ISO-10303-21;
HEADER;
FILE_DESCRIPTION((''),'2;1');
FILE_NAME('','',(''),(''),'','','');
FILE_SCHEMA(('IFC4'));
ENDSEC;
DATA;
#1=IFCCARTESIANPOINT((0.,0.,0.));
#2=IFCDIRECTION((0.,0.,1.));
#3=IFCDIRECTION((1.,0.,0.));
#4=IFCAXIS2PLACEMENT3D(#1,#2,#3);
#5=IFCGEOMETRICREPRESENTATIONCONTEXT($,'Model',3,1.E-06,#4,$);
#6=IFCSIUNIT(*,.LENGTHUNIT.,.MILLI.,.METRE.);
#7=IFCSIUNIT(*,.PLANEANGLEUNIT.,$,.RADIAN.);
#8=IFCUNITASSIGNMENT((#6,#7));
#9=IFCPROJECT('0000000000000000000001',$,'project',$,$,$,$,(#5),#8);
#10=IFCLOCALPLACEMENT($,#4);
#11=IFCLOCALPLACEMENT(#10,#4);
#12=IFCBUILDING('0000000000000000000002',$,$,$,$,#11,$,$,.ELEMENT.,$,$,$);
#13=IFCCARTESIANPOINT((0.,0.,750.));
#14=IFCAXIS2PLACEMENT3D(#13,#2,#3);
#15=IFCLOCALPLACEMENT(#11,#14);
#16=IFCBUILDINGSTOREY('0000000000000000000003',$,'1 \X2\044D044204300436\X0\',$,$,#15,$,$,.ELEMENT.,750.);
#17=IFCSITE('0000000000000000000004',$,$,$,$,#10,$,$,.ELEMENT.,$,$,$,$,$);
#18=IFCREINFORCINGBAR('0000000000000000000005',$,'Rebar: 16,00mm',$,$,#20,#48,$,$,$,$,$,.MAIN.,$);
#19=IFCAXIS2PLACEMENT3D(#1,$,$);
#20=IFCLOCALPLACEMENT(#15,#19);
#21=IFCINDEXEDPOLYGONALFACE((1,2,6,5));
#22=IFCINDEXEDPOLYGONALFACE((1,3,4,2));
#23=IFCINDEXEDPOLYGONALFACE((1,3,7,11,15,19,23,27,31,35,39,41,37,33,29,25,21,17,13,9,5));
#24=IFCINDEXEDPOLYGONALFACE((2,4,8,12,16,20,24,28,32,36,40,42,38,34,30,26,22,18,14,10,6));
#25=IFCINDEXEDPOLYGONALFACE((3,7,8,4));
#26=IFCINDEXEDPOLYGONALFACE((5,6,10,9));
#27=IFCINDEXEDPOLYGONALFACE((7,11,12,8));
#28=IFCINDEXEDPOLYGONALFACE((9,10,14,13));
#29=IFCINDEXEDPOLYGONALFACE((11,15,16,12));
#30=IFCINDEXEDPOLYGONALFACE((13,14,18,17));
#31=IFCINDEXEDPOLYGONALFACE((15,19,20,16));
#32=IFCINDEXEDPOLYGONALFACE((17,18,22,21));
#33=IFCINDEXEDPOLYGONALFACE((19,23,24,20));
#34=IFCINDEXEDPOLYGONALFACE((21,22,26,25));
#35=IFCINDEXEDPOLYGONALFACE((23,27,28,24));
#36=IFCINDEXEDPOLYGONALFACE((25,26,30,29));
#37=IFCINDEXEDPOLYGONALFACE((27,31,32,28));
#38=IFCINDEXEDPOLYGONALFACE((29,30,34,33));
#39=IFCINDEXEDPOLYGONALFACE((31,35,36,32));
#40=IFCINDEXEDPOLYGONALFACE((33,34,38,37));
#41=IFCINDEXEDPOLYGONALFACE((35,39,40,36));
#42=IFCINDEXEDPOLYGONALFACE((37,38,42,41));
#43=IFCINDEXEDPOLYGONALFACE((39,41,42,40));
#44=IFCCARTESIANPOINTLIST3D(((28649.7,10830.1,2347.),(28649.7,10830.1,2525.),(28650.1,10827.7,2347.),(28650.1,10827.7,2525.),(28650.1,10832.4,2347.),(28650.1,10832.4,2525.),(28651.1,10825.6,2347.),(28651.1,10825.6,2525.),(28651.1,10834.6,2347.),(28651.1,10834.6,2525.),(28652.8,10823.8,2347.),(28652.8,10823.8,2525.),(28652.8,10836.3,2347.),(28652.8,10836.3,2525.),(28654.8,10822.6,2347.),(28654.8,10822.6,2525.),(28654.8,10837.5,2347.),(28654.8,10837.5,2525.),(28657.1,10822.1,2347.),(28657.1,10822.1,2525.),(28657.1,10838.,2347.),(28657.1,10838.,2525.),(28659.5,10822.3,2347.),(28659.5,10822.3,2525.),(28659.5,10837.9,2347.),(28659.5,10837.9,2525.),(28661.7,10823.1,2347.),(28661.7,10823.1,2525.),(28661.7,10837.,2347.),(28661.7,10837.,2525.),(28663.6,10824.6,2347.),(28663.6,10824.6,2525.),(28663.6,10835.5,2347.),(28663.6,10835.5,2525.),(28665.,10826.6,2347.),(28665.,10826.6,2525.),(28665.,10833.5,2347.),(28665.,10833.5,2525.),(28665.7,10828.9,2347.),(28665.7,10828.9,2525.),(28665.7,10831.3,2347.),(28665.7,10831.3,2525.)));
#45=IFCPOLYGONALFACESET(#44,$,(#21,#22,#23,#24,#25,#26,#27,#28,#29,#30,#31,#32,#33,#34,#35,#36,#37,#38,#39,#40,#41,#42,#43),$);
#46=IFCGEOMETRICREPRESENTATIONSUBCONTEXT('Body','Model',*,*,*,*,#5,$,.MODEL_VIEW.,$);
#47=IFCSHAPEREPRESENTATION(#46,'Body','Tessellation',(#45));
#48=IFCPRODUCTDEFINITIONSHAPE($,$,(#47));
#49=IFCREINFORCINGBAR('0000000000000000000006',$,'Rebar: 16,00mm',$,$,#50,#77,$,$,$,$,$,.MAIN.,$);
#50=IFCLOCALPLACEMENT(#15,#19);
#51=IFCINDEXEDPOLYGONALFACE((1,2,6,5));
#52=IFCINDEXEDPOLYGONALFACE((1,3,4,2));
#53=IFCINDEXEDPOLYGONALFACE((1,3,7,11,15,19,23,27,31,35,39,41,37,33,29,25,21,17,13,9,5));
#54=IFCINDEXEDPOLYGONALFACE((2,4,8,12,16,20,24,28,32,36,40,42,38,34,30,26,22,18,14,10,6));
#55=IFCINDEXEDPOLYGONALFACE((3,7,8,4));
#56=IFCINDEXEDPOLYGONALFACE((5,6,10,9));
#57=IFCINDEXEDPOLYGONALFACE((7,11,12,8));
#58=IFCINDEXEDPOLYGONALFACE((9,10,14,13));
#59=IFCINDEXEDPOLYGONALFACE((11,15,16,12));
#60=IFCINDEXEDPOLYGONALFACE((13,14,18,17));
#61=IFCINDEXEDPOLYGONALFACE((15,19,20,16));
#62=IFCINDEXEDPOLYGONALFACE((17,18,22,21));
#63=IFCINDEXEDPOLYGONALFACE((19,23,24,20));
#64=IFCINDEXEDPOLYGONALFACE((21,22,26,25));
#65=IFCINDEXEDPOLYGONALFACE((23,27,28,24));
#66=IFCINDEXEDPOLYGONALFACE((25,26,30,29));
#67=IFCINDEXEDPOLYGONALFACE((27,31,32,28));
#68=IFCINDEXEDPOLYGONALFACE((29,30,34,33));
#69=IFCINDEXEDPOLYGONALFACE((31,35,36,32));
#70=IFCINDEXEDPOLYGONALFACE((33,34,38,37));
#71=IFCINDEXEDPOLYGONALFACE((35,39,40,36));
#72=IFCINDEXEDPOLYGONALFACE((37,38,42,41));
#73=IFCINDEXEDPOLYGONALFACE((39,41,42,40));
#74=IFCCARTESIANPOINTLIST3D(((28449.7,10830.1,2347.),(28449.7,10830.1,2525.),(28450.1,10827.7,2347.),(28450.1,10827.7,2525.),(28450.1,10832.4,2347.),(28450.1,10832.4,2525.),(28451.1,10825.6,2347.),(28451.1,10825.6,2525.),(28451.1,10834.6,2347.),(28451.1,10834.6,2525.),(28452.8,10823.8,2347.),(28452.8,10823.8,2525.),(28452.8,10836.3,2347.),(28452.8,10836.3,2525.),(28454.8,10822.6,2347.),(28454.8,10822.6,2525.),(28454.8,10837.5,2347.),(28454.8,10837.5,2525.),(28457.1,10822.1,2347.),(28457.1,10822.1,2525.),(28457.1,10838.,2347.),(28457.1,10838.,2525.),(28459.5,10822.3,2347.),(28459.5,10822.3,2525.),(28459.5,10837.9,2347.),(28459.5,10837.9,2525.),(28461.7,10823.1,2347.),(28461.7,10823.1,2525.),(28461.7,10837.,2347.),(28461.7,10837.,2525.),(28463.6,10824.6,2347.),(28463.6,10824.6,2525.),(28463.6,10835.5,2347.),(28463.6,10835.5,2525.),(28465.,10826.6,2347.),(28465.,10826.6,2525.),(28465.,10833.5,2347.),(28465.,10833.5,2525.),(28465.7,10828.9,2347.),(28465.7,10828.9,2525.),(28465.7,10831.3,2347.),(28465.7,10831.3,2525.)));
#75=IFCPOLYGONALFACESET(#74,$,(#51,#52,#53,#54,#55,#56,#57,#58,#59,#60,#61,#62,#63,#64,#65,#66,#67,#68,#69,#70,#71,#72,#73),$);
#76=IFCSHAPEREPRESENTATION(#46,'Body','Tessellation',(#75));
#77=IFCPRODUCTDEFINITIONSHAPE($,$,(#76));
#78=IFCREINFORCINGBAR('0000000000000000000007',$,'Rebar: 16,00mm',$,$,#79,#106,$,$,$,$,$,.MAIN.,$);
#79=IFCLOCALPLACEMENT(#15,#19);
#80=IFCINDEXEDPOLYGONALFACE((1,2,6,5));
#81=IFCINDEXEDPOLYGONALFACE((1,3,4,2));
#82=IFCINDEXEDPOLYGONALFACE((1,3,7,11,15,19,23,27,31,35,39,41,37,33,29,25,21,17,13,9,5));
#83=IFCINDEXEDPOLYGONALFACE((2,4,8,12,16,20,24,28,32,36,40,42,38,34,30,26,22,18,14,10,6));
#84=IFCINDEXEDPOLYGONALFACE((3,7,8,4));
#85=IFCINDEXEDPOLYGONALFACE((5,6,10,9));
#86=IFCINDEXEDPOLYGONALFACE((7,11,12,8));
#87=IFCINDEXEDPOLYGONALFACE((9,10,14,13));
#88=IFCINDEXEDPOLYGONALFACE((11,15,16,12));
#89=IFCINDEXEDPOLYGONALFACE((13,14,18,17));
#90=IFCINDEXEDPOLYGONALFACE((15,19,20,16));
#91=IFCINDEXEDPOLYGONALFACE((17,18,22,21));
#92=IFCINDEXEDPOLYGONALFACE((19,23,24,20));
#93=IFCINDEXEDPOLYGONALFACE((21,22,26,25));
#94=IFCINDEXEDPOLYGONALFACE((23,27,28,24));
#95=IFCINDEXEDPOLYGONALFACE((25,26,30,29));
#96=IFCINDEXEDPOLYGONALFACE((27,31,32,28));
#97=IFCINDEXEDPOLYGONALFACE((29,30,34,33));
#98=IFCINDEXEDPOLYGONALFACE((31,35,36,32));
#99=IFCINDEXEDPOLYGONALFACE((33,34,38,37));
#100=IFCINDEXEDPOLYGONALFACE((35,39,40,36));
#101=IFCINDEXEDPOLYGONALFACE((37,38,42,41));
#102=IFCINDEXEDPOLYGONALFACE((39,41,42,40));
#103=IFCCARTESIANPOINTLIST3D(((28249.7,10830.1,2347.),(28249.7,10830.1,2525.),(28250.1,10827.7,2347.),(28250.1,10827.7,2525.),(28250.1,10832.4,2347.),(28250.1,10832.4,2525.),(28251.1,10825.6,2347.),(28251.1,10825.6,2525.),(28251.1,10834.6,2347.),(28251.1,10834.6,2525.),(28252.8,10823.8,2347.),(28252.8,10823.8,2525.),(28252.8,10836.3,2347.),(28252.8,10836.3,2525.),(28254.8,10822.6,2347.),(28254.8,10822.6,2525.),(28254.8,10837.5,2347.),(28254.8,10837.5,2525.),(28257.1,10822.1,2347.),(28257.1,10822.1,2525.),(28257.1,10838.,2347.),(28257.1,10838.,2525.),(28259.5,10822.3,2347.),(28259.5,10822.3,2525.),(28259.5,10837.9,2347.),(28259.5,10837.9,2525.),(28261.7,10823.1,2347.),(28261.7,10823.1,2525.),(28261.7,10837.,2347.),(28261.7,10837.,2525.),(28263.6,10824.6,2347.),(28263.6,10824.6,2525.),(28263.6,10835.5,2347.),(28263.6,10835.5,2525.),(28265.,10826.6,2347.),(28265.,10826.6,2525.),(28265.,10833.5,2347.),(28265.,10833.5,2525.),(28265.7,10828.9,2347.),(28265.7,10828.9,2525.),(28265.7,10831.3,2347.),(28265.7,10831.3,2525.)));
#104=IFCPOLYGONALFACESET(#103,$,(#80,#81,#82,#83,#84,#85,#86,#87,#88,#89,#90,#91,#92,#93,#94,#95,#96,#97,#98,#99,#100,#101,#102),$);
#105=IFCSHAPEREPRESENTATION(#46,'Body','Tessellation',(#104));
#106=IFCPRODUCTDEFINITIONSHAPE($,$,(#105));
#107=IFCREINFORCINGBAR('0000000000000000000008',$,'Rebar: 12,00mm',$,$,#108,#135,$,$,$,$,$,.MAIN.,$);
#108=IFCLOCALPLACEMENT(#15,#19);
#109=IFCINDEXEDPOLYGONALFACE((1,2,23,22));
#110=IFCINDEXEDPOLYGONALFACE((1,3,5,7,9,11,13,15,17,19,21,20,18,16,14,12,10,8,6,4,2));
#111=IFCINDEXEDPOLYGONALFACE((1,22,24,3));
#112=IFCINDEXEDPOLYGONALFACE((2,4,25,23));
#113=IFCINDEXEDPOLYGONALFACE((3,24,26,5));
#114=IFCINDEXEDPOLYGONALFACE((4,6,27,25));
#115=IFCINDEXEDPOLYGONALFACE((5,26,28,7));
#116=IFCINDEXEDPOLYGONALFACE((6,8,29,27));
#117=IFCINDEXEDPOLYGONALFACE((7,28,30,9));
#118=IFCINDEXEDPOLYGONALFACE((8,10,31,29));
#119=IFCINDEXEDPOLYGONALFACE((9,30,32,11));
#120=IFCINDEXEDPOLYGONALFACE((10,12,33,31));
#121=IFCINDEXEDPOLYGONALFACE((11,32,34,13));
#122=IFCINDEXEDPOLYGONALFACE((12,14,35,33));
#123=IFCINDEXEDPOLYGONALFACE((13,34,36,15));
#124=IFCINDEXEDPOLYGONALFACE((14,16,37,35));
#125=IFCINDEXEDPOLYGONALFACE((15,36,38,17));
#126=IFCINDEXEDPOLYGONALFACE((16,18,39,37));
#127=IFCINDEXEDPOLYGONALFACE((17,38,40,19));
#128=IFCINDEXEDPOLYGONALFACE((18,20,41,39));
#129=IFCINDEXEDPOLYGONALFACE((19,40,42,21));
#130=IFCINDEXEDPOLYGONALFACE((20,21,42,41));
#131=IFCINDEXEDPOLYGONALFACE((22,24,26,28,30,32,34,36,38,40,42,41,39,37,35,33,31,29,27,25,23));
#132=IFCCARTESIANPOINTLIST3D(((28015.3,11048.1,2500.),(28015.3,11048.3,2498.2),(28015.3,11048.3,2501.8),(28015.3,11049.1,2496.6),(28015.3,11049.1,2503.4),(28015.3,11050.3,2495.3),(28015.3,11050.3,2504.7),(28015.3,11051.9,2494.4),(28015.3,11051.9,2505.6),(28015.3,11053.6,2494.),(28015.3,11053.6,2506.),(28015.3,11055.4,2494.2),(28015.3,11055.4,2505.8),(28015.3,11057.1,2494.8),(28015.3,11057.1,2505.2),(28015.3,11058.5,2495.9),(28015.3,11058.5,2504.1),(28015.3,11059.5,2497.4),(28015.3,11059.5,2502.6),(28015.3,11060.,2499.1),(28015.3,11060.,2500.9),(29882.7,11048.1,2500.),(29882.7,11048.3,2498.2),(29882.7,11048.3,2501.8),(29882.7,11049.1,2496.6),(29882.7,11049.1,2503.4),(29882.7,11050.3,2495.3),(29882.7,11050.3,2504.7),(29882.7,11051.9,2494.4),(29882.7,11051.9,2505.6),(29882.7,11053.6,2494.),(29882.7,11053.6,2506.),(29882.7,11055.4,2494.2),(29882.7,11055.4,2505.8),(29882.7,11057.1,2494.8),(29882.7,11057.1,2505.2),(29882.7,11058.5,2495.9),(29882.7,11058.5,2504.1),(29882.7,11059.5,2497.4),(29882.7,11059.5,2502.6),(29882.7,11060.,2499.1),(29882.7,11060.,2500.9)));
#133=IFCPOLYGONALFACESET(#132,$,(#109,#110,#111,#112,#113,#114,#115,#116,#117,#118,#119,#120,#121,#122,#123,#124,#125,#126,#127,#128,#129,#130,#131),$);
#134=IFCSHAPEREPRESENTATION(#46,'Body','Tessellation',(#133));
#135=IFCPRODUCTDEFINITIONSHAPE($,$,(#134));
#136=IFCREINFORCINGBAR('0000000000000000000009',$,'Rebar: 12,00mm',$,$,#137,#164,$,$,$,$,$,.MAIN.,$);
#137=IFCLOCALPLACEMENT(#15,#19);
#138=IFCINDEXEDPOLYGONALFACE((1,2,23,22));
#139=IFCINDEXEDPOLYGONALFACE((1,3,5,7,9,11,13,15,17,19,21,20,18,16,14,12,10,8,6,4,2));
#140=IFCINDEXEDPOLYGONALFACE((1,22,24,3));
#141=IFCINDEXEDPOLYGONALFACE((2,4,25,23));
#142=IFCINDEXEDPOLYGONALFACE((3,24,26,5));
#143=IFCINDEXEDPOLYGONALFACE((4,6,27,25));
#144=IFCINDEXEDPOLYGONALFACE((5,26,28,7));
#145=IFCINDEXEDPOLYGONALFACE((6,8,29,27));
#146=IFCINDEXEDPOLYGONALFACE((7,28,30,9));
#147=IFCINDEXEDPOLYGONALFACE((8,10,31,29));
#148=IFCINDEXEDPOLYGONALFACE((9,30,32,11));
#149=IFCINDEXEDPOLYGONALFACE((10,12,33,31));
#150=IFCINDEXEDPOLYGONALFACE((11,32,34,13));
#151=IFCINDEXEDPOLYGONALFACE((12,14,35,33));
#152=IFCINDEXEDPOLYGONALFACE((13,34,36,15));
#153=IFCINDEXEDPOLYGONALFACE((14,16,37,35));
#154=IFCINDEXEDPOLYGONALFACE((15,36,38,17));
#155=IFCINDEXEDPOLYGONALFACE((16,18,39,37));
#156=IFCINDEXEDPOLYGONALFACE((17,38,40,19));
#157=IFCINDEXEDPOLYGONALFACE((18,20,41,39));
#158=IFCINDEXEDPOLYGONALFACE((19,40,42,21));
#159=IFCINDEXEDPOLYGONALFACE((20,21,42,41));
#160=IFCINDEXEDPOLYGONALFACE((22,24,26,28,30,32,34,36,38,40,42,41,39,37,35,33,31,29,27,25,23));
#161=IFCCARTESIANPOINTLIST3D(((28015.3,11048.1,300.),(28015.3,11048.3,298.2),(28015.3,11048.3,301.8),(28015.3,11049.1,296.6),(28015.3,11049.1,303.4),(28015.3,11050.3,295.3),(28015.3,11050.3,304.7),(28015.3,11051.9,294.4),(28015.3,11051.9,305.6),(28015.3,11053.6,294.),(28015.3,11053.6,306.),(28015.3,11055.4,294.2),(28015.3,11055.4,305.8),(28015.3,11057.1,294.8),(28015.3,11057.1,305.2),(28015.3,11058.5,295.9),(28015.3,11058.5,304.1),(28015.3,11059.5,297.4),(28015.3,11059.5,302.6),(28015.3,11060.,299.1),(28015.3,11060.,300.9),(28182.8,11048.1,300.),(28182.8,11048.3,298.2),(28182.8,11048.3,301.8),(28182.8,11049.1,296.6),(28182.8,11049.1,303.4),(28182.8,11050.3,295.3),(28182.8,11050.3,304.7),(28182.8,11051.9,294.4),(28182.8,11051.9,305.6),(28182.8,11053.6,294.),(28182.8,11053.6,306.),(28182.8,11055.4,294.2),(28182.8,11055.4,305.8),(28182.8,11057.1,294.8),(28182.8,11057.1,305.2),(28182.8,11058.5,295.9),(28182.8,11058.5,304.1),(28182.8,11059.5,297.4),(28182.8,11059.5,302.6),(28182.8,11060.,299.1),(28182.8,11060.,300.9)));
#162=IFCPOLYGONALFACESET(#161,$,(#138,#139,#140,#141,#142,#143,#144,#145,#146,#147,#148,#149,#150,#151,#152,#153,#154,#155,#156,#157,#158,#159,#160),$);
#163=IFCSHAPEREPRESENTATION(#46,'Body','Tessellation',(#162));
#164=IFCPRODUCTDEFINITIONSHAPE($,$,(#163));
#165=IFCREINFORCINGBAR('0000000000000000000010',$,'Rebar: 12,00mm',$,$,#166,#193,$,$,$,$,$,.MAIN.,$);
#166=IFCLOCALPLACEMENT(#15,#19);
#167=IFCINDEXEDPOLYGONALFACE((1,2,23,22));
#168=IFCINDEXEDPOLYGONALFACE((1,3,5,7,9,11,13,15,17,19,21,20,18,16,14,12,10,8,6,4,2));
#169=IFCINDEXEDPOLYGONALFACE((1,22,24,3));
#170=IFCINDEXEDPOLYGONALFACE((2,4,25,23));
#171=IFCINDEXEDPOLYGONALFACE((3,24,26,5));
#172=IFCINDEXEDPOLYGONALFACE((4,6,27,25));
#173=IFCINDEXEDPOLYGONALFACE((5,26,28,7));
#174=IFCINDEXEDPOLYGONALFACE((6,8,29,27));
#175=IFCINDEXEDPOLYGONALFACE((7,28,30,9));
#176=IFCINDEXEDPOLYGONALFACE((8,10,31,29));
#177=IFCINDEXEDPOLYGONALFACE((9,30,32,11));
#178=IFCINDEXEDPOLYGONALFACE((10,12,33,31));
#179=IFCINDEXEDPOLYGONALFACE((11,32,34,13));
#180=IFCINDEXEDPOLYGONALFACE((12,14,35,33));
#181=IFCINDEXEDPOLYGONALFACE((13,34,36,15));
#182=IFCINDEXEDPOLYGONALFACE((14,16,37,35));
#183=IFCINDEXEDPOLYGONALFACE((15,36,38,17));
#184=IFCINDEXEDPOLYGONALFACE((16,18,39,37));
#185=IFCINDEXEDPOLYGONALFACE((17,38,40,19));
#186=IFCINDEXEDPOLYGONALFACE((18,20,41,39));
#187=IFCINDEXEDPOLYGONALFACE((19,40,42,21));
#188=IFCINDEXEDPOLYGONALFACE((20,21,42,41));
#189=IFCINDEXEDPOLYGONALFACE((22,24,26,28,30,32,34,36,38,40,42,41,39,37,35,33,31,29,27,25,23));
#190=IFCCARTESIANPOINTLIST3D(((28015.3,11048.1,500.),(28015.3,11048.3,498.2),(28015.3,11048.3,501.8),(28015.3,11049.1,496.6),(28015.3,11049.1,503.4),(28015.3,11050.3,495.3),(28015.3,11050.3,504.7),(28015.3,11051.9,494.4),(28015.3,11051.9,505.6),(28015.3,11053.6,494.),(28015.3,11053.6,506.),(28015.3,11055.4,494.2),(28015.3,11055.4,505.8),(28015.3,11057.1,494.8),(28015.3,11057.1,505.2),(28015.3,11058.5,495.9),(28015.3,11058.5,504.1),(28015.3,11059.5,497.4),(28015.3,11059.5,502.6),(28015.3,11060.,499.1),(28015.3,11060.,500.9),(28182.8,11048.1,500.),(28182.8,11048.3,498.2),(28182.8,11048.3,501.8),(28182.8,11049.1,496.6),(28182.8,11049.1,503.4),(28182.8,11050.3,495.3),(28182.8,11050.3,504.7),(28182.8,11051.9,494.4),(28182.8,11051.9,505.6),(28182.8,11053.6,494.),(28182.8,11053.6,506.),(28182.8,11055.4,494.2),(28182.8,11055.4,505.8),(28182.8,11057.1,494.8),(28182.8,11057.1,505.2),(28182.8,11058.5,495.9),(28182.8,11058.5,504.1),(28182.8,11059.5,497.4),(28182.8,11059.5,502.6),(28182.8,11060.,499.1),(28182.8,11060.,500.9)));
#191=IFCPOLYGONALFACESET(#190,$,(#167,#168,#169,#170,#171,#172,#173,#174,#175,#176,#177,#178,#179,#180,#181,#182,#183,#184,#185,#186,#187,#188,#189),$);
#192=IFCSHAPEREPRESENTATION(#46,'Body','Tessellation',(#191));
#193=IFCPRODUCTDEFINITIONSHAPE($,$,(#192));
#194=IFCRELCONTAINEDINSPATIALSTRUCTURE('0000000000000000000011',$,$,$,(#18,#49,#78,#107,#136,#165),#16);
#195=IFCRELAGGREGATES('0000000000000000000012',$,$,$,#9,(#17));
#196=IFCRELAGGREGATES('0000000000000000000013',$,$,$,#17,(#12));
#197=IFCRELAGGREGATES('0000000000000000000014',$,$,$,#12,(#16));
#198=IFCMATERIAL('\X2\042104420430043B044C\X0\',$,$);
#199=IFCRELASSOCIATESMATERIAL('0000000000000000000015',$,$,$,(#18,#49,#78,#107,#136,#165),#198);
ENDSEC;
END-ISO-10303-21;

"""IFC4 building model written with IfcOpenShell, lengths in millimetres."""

from ifc_helpers import new_model, entity, si_unit, frame, origin_with_axes, place, context, subcontext, project, spatial, source, transform, mapped, material, element, save


model = new_model("IFC4")

# Units and contexts
model_context = context("Model", 3, precision=1e-06, world=origin_with_axes())
body_context = subcontext(model_context, "Body", "Model", "MODEL_VIEW")
ifc_project = project(units=[si_unit("LENGTHUNIT", "METRE", prefix="MILLI"), si_unit("PLANEANGLEUNIT", "RADIAN")], contexts=[model_context])

# Site, building, storey
site_placement = place(None, origin_with_axes())
site = spatial("IfcSite", under=ifc_project, at=site_placement, CompositionType="ELEMENT")
building_placement = place(site_placement, origin_with_axes())
building = spatial("IfcBuilding", under=site, at=building_placement, CompositionType="ELEMENT")
storey_placement = place(building_placement, frame((0.0, 0.0, 750.0), z_axis=(0.0, 0.0, 1.0), x_axis=(1.0, 0.0, 0.0)))
storey = spatial("IfcBuildingStorey", under=building, at=storey_placement, Name="1 этаж", CompositionType="ELEMENT", Elevation=750.0)

# Reinforcing bars
ifc_material = material(Name="Сталь")
shared_shape_1 = source(origin_with_axes(), body_context, "Body", "AdvancedSweptSolid", [
    entity("IfcSweptDiskSolid", entity("IfcIndexedPolyCurve", entity("IfcCartesianPointList3D", [[0.0, 0.0, 0.0], [178.0, 0.0, 0.0]]), [entity("IfcLineIndex", [1, 2])]), 8.0),
])
reinforcing_bar_1_placement = place(storey_placement, origin_with_axes())
element("IfcReinforcingBar", 1, at=reinforcing_bar_1_placement, inside=storey, material=ifc_material, Name="Rebar: 16,00mm", PredefinedType="MAIN", context=body_context, shape_type="MappedRepresentation", body=[
    mapped(shared_shape_1, transform((28657.7, 10830.1, 2347.0), x_axis=(0.0, 0.0, 1.0), y_axis=(0.0, 1.0, 0.0), z_axis=(-1.0, 0.0, 0.0), scale=1.0)),
])
reinforcing_bar_2_placement = place(storey_placement, origin_with_axes())
element("IfcReinforcingBar", 2, at=reinforcing_bar_2_placement, inside=storey, material=ifc_material, Name="Rebar: 16,00mm", PredefinedType="MAIN", context=body_context, shape_type="MappedRepresentation", body=[
    mapped(shared_shape_1, transform((28457.7, 10830.1, 2347.0), x_axis=(0.0, 0.0, 1.0), y_axis=(0.0, 1.0, 0.0), z_axis=(-1.0, 0.0, 0.0), scale=1.0)),
])
reinforcing_bar_3_placement = place(storey_placement, origin_with_axes())
element("IfcReinforcingBar", 3, at=reinforcing_bar_3_placement, inside=storey, material=ifc_material, Name="Rebar: 16,00mm", PredefinedType="MAIN", context=body_context, shape_type="MappedRepresentation", body=[
    mapped(shared_shape_1, transform((28257.7, 10830.1, 2347.0), x_axis=(0.0, 0.0, 1.0), y_axis=(0.0, 1.0, 0.0), z_axis=(-1.0, 0.0, 0.0), scale=1.0)),
])
shared_shape_2 = source(origin_with_axes(), body_context, "Body", "AdvancedSweptSolid", [
    entity("IfcSweptDiskSolid", entity("IfcIndexedPolyCurve", entity("IfcCartesianPointList3D", [[0.0, 0.0, 0.0], [1867.5, 0.0, 0.0]]), [entity("IfcLineIndex", [1, 2])]), 6.0),
])
reinforcing_bar_4_placement = place(storey_placement, origin_with_axes())
element("IfcReinforcingBar", 4, at=reinforcing_bar_4_placement, inside=storey, material=ifc_material, Name="Rebar: 12,00mm", PredefinedType="MAIN", context=body_context, shape_type="MappedRepresentation", body=[
    mapped(shared_shape_2, transform((29882.7, 11054.1, 2500.0), x_axis=(-1.0, 0.0, 0.0), y_axis=(0.0, -1.0, 0.0), z_axis=(0.0, 0.0, 1.0), scale=1.0)),
])
shared_shape_3 = source(origin_with_axes(), body_context, "Body", "AdvancedSweptSolid", [
    entity("IfcSweptDiskSolid", entity("IfcIndexedPolyCurve", entity("IfcCartesianPointList3D", [[0.0, 0.0, 0.0], [167.5, 0.0, 0.0]]), [entity("IfcLineIndex", [1, 2])]), 6.0),
])
reinforcing_bar_5_placement = place(storey_placement, origin_with_axes())
element("IfcReinforcingBar", 5, at=reinforcing_bar_5_placement, inside=storey, material=ifc_material, Name="Rebar: 12,00mm", PredefinedType="MAIN", context=body_context, shape_type="MappedRepresentation", body=[
    mapped(shared_shape_3, transform((28182.8, 11054.1, 300.0), x_axis=(-1.0, 0.0, 0.0), y_axis=(0.0, -1.0, 0.0), z_axis=(0.0, 0.0, 1.0), scale=1.0)),
])
reinforcing_bar_6_placement = place(storey_placement, origin_with_axes())
element("IfcReinforcingBar", 6, at=reinforcing_bar_6_placement, inside=storey, material=ifc_material, Name="Rebar: 12,00mm", PredefinedType="MAIN", context=body_context, shape_type="MappedRepresentation", body=[
    mapped(shared_shape_3, transform((28182.8, 11054.1, 500.0), x_axis=(-1.0, 0.0, 0.0), y_axis=(0.0, -1.0, 0.0), z_axis=(0.0, 0.0, 1.0), scale=1.0)),
])

save(model, "model.ifc")
